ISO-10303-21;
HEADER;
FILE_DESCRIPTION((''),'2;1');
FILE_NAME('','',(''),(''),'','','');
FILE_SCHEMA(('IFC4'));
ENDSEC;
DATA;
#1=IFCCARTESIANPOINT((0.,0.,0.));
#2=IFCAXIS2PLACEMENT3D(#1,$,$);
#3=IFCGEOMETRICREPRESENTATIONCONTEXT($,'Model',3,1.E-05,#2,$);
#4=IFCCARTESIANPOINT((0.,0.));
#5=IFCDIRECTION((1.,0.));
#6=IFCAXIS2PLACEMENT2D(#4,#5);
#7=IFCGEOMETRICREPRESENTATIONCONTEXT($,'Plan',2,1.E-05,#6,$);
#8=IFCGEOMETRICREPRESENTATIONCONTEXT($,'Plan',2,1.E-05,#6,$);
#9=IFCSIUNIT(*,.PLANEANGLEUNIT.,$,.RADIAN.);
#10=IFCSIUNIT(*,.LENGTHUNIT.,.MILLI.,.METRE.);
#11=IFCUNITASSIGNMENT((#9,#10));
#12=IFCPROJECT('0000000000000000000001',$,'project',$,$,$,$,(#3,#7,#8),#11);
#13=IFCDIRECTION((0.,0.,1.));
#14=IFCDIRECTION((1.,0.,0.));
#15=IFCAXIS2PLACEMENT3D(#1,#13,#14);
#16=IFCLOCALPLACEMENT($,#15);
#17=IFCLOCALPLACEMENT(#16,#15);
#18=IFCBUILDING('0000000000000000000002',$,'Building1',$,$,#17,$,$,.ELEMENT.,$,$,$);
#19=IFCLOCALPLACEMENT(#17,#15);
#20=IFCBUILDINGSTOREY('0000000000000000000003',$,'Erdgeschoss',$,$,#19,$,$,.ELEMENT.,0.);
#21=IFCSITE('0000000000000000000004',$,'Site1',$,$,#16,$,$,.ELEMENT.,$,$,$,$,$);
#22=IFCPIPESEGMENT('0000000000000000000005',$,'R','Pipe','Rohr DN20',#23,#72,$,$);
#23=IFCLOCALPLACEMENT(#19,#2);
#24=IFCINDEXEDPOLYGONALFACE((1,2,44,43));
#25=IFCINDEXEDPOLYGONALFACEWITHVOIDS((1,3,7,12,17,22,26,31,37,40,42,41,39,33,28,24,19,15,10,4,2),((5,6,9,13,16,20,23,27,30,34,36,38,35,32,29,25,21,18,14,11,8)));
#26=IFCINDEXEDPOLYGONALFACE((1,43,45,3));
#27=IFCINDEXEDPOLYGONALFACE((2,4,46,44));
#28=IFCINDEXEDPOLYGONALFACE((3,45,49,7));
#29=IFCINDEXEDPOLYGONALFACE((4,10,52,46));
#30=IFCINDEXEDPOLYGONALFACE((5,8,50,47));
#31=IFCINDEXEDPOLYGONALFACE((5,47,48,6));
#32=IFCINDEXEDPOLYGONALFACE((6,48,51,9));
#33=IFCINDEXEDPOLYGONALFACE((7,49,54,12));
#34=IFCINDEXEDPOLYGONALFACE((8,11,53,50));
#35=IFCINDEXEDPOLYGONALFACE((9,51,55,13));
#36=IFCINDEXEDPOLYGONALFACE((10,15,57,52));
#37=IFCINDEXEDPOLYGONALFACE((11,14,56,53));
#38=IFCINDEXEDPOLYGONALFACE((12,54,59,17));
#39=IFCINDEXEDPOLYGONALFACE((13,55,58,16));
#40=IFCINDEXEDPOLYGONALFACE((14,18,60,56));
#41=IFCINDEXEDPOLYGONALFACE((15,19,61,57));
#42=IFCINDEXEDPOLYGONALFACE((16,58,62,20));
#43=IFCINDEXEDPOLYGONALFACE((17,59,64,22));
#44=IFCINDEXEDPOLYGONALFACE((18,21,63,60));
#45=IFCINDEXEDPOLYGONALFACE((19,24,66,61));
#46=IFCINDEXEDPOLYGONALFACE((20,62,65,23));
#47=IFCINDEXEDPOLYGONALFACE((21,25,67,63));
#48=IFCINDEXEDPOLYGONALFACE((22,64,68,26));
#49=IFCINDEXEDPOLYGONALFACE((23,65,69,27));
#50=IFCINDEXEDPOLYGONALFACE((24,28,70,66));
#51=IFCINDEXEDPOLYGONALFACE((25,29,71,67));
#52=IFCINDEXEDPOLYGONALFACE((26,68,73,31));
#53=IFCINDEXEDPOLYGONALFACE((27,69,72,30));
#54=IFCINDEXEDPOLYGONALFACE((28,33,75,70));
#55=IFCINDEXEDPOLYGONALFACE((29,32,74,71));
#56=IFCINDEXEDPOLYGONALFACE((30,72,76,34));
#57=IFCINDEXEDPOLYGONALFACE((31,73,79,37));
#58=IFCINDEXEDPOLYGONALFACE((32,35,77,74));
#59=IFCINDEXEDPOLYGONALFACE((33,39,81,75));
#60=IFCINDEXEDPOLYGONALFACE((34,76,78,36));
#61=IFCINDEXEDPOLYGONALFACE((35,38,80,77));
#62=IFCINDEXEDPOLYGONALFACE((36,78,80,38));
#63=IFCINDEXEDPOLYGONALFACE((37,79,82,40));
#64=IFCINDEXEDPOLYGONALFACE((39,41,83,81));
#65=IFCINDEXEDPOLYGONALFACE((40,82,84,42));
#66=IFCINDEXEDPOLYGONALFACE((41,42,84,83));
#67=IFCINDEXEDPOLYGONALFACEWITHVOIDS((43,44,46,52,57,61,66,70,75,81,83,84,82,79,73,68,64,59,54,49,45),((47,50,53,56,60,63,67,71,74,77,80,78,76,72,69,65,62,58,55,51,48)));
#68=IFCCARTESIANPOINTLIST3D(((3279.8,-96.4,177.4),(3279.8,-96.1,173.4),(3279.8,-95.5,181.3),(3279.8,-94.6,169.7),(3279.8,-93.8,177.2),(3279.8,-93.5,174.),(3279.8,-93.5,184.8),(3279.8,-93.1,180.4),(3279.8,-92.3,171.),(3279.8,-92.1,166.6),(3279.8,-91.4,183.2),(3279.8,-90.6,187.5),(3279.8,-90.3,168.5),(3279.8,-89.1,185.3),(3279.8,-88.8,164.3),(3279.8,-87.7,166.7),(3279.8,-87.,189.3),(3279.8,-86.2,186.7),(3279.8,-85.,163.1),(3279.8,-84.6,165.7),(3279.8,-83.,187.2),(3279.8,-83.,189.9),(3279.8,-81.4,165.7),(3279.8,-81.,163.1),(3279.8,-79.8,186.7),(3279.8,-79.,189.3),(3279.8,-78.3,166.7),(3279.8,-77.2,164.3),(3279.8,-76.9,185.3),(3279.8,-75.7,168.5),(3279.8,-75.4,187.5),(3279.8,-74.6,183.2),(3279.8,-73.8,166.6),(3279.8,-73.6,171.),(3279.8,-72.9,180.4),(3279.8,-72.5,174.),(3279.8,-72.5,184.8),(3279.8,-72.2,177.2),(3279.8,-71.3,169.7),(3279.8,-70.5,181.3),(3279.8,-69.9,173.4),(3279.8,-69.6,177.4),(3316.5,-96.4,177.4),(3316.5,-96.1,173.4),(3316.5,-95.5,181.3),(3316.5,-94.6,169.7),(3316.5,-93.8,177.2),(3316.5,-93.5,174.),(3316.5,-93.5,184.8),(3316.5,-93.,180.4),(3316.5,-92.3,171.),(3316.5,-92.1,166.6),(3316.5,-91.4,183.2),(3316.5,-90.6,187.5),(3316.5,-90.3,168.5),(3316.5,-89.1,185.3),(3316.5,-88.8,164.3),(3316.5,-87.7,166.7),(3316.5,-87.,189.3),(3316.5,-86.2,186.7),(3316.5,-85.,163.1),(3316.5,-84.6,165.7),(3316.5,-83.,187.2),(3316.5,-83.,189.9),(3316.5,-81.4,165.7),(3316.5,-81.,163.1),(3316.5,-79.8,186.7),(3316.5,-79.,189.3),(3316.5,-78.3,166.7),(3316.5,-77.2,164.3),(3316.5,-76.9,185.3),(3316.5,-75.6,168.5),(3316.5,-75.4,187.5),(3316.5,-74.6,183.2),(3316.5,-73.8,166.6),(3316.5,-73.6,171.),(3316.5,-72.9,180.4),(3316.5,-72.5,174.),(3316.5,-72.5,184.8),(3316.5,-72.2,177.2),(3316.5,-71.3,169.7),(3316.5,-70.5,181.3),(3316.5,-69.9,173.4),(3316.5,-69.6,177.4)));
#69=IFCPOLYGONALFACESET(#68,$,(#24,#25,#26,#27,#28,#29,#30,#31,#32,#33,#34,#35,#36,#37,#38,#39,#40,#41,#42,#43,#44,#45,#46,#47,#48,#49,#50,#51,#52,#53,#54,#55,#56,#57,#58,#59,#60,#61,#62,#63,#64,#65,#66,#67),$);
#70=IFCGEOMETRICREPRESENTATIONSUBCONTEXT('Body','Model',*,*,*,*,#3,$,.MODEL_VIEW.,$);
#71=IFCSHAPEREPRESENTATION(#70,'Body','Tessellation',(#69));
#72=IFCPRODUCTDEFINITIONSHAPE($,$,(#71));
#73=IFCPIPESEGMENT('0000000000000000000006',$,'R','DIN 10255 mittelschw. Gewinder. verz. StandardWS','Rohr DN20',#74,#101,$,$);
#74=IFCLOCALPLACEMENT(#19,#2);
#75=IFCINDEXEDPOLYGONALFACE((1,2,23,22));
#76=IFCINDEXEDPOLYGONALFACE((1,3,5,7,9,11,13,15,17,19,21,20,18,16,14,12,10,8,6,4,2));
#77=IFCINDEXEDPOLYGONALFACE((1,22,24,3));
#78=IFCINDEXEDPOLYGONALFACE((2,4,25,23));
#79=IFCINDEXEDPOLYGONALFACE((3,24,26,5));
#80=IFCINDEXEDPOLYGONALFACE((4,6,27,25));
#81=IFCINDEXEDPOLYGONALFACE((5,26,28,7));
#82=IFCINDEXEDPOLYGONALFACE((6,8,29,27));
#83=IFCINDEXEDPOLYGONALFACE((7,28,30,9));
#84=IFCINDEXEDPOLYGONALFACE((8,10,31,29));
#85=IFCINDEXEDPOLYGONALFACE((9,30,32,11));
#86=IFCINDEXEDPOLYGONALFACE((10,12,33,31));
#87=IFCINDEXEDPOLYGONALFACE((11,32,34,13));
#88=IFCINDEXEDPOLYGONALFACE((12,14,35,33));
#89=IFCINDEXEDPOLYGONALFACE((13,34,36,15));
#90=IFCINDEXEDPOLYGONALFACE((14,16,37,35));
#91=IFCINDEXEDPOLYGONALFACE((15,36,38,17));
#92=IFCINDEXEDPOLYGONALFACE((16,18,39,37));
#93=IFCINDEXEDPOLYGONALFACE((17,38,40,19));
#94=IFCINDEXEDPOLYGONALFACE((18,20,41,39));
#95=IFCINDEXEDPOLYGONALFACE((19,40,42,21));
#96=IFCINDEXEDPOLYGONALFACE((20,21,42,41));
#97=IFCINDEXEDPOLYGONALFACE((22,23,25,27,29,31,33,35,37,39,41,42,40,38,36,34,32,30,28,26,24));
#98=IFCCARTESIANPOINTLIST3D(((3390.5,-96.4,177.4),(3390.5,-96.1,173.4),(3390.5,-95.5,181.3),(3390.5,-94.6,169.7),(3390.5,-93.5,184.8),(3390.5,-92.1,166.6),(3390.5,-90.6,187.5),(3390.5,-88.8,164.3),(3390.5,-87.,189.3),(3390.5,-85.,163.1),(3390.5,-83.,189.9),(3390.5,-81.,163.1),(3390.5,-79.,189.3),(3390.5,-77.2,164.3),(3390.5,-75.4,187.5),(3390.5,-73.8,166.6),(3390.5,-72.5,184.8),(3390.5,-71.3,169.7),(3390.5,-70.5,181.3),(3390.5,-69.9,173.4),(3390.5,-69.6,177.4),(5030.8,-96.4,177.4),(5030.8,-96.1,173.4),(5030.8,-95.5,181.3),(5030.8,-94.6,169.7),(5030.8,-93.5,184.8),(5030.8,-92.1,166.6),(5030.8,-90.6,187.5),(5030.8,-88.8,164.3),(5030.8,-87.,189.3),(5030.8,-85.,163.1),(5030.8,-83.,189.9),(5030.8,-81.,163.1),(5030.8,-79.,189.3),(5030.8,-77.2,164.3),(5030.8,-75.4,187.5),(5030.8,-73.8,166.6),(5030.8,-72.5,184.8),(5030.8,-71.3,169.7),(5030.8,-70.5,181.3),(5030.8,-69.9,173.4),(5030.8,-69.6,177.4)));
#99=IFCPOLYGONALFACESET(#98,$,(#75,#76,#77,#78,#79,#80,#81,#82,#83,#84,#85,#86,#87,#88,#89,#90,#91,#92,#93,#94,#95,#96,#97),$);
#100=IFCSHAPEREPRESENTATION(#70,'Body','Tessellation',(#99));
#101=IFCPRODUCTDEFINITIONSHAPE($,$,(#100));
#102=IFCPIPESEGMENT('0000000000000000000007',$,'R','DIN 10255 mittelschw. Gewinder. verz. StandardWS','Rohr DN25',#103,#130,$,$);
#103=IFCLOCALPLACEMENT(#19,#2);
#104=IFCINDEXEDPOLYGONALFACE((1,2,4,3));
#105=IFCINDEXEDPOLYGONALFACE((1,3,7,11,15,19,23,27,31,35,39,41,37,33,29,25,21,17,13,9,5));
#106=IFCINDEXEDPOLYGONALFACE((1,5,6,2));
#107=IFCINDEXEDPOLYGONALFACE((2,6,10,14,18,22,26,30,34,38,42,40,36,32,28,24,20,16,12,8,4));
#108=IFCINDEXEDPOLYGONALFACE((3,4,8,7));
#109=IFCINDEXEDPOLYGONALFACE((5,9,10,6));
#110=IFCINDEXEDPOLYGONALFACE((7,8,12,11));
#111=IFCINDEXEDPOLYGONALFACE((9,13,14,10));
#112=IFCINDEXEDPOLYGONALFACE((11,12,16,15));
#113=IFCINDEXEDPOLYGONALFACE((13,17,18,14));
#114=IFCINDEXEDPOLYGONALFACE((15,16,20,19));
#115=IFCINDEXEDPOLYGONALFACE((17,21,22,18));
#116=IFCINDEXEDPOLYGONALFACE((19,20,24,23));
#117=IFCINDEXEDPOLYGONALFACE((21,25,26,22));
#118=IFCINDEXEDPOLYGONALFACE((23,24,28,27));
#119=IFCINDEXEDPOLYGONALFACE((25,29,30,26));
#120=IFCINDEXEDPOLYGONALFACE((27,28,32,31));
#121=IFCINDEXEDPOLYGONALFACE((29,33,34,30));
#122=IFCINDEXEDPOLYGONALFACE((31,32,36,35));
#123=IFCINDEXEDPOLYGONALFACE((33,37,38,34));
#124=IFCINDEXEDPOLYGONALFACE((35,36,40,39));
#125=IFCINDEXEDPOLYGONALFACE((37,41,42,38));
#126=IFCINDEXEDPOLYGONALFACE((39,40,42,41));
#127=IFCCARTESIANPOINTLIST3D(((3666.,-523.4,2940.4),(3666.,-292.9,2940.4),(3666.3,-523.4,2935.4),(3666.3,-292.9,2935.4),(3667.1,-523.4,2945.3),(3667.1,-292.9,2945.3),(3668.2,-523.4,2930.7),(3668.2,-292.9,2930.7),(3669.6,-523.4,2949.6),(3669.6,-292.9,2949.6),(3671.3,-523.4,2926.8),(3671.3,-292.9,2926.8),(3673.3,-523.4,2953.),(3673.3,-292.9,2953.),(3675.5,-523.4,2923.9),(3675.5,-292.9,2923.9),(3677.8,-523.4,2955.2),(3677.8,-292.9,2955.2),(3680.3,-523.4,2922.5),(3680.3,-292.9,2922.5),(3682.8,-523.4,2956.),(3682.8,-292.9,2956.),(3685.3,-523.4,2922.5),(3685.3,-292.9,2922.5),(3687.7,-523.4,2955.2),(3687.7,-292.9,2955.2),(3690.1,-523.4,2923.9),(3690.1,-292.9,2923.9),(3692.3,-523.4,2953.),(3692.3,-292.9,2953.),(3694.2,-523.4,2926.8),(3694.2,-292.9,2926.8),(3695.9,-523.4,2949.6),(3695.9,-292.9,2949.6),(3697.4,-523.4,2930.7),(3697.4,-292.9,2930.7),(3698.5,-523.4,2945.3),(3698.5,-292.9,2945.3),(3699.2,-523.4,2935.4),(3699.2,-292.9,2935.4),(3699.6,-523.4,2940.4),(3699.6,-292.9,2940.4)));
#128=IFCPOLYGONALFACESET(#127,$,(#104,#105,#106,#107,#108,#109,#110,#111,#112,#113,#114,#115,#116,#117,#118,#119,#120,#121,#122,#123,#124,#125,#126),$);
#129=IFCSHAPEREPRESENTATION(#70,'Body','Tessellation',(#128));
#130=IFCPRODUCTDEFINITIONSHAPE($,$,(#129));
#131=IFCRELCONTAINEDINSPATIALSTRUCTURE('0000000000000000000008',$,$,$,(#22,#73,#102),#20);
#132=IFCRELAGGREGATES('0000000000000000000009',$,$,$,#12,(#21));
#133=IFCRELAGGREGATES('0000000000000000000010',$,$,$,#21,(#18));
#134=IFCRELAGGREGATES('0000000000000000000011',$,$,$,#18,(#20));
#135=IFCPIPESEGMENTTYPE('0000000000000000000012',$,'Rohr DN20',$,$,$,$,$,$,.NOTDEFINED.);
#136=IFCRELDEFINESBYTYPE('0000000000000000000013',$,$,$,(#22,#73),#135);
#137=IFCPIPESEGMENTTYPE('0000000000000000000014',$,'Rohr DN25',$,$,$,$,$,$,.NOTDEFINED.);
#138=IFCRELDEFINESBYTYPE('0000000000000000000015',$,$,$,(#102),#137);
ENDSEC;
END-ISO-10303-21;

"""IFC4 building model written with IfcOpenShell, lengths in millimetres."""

from ifc_helpers import new_model, si_unit, frame, origin, origin_with_axes, origin_2d_with_axis, place, context, subcontext, project, spatial, circle, hollow_circle, extrude, type_object, element, save


model = new_model("IFC4")

# Units and contexts
model_context = context("Model", 3, precision=1e-05, world=origin())
plan_context_1 = context("Plan", 2, precision=1e-05, world=origin_2d_with_axis())
plan_context_2 = context("Plan", 2, precision=1e-05, world=origin_2d_with_axis())
body_context = subcontext(model_context, "Body", "Model", "MODEL_VIEW")
ifc_project = project(units=[si_unit("PLANEANGLEUNIT", "RADIAN"), si_unit("LENGTHUNIT", "METRE", prefix="MILLI")], contexts=[model_context, plan_context_1, plan_context_2])

# Site, building, storey
site_placement = place(None, origin_with_axes())
site = spatial("IfcSite", under=ifc_project, at=site_placement, Name="Site1", CompositionType="ELEMENT")
building_placement = place(site_placement, origin_with_axes())
building = spatial("IfcBuilding", under=site, at=building_placement, Name="Building1", CompositionType="ELEMENT")
storey_placement = place(building_placement, origin_with_axes())
storey = spatial("IfcBuildingStorey", under=building, at=storey_placement, Name="Erdgeschoss", CompositionType="ELEMENT", Elevation=0.0)

# Pipe segments
pipe_segment_type_1 = type_object("IfcPipeSegmentType", Name="Rohr DN20", PredefinedType="NOTDEFINED")
pipe_segment_1_placement = place(storey_placement, frame((3298.1, -82.8, 176.4), z_axis=(0.0, 0.0, 1.0), x_axis=(1.0, 0.0, 0.0)))
element("IfcPipeSegment", 1, at=pipe_segment_1_placement, inside=storey, type_object=pipe_segment_type_1, Name="R", Description="Pipe", ObjectType="Rohr DN20", context=body_context, shape_type="SolidModel", body=[
    extrude(hollow_circle(Radius=13.4, WallThickness=2.6, at=origin_2d_with_axis()), frame((-18.4, -0.2, 0.0), z_axis=(1.0, 0.000064, -0.000089), x_axis=(0.0, 0.0, 1.0)), (0.0, 0.0, 1.0), 36.7),
])
pipe_segment_2_placement = place(storey_placement, frame((4210.6, -83.1, 176.4), z_axis=(0.0, 0.0, 1.0), x_axis=(1.0, 0.0, 0.0)))
element("IfcPipeSegment", 2, at=pipe_segment_2_placement, inside=storey, type_object=pipe_segment_type_1, Name="R", Description="DIN 10255 mittelschw. Gewinder. verz. StandardWS", ObjectType="Rohr DN20", context=body_context, shape_type="SolidModel", body=[
    extrude(circle(Radius=13.4, at=origin_2d_with_axis()), frame((820.1, 0.1, 0.0), z_axis=(-1.0, 0.000001, -0.000002), x_axis=(0.0, 0.0, 1.0)), (0.0, 0.0, 1.0), 1640.3),
])
pipe_segment_type_2 = type_object("IfcPipeSegmentType", Name="Rohr DN25", PredefinedType="NOTDEFINED")
pipe_segment_3_placement = place(storey_placement, frame((3682.6, -408.1, 2939.1), z_axis=(0.0, 0.0, 1.0), x_axis=(1.0, 0.0, 0.0)))
element("IfcPipeSegment", 3, at=pipe_segment_3_placement, inside=storey, type_object=pipe_segment_type_2, Name="R", Description="DIN 10255 mittelschw. Gewinder. verz. StandardWS", ObjectType="Rohr DN25", context=body_context, shape_type="SolidModel", body=[
    extrude(circle(Radius=16.9, at=origin_2d_with_axis()), frame((0.2, -115.3, 0.0), z_axis=(0.0, 1.0, 0.0), x_axis=(0.0, 0.0, 1.0)), (0.0, 0.0, 1.0), 230.5),
])

save(model, "model.ifc")
